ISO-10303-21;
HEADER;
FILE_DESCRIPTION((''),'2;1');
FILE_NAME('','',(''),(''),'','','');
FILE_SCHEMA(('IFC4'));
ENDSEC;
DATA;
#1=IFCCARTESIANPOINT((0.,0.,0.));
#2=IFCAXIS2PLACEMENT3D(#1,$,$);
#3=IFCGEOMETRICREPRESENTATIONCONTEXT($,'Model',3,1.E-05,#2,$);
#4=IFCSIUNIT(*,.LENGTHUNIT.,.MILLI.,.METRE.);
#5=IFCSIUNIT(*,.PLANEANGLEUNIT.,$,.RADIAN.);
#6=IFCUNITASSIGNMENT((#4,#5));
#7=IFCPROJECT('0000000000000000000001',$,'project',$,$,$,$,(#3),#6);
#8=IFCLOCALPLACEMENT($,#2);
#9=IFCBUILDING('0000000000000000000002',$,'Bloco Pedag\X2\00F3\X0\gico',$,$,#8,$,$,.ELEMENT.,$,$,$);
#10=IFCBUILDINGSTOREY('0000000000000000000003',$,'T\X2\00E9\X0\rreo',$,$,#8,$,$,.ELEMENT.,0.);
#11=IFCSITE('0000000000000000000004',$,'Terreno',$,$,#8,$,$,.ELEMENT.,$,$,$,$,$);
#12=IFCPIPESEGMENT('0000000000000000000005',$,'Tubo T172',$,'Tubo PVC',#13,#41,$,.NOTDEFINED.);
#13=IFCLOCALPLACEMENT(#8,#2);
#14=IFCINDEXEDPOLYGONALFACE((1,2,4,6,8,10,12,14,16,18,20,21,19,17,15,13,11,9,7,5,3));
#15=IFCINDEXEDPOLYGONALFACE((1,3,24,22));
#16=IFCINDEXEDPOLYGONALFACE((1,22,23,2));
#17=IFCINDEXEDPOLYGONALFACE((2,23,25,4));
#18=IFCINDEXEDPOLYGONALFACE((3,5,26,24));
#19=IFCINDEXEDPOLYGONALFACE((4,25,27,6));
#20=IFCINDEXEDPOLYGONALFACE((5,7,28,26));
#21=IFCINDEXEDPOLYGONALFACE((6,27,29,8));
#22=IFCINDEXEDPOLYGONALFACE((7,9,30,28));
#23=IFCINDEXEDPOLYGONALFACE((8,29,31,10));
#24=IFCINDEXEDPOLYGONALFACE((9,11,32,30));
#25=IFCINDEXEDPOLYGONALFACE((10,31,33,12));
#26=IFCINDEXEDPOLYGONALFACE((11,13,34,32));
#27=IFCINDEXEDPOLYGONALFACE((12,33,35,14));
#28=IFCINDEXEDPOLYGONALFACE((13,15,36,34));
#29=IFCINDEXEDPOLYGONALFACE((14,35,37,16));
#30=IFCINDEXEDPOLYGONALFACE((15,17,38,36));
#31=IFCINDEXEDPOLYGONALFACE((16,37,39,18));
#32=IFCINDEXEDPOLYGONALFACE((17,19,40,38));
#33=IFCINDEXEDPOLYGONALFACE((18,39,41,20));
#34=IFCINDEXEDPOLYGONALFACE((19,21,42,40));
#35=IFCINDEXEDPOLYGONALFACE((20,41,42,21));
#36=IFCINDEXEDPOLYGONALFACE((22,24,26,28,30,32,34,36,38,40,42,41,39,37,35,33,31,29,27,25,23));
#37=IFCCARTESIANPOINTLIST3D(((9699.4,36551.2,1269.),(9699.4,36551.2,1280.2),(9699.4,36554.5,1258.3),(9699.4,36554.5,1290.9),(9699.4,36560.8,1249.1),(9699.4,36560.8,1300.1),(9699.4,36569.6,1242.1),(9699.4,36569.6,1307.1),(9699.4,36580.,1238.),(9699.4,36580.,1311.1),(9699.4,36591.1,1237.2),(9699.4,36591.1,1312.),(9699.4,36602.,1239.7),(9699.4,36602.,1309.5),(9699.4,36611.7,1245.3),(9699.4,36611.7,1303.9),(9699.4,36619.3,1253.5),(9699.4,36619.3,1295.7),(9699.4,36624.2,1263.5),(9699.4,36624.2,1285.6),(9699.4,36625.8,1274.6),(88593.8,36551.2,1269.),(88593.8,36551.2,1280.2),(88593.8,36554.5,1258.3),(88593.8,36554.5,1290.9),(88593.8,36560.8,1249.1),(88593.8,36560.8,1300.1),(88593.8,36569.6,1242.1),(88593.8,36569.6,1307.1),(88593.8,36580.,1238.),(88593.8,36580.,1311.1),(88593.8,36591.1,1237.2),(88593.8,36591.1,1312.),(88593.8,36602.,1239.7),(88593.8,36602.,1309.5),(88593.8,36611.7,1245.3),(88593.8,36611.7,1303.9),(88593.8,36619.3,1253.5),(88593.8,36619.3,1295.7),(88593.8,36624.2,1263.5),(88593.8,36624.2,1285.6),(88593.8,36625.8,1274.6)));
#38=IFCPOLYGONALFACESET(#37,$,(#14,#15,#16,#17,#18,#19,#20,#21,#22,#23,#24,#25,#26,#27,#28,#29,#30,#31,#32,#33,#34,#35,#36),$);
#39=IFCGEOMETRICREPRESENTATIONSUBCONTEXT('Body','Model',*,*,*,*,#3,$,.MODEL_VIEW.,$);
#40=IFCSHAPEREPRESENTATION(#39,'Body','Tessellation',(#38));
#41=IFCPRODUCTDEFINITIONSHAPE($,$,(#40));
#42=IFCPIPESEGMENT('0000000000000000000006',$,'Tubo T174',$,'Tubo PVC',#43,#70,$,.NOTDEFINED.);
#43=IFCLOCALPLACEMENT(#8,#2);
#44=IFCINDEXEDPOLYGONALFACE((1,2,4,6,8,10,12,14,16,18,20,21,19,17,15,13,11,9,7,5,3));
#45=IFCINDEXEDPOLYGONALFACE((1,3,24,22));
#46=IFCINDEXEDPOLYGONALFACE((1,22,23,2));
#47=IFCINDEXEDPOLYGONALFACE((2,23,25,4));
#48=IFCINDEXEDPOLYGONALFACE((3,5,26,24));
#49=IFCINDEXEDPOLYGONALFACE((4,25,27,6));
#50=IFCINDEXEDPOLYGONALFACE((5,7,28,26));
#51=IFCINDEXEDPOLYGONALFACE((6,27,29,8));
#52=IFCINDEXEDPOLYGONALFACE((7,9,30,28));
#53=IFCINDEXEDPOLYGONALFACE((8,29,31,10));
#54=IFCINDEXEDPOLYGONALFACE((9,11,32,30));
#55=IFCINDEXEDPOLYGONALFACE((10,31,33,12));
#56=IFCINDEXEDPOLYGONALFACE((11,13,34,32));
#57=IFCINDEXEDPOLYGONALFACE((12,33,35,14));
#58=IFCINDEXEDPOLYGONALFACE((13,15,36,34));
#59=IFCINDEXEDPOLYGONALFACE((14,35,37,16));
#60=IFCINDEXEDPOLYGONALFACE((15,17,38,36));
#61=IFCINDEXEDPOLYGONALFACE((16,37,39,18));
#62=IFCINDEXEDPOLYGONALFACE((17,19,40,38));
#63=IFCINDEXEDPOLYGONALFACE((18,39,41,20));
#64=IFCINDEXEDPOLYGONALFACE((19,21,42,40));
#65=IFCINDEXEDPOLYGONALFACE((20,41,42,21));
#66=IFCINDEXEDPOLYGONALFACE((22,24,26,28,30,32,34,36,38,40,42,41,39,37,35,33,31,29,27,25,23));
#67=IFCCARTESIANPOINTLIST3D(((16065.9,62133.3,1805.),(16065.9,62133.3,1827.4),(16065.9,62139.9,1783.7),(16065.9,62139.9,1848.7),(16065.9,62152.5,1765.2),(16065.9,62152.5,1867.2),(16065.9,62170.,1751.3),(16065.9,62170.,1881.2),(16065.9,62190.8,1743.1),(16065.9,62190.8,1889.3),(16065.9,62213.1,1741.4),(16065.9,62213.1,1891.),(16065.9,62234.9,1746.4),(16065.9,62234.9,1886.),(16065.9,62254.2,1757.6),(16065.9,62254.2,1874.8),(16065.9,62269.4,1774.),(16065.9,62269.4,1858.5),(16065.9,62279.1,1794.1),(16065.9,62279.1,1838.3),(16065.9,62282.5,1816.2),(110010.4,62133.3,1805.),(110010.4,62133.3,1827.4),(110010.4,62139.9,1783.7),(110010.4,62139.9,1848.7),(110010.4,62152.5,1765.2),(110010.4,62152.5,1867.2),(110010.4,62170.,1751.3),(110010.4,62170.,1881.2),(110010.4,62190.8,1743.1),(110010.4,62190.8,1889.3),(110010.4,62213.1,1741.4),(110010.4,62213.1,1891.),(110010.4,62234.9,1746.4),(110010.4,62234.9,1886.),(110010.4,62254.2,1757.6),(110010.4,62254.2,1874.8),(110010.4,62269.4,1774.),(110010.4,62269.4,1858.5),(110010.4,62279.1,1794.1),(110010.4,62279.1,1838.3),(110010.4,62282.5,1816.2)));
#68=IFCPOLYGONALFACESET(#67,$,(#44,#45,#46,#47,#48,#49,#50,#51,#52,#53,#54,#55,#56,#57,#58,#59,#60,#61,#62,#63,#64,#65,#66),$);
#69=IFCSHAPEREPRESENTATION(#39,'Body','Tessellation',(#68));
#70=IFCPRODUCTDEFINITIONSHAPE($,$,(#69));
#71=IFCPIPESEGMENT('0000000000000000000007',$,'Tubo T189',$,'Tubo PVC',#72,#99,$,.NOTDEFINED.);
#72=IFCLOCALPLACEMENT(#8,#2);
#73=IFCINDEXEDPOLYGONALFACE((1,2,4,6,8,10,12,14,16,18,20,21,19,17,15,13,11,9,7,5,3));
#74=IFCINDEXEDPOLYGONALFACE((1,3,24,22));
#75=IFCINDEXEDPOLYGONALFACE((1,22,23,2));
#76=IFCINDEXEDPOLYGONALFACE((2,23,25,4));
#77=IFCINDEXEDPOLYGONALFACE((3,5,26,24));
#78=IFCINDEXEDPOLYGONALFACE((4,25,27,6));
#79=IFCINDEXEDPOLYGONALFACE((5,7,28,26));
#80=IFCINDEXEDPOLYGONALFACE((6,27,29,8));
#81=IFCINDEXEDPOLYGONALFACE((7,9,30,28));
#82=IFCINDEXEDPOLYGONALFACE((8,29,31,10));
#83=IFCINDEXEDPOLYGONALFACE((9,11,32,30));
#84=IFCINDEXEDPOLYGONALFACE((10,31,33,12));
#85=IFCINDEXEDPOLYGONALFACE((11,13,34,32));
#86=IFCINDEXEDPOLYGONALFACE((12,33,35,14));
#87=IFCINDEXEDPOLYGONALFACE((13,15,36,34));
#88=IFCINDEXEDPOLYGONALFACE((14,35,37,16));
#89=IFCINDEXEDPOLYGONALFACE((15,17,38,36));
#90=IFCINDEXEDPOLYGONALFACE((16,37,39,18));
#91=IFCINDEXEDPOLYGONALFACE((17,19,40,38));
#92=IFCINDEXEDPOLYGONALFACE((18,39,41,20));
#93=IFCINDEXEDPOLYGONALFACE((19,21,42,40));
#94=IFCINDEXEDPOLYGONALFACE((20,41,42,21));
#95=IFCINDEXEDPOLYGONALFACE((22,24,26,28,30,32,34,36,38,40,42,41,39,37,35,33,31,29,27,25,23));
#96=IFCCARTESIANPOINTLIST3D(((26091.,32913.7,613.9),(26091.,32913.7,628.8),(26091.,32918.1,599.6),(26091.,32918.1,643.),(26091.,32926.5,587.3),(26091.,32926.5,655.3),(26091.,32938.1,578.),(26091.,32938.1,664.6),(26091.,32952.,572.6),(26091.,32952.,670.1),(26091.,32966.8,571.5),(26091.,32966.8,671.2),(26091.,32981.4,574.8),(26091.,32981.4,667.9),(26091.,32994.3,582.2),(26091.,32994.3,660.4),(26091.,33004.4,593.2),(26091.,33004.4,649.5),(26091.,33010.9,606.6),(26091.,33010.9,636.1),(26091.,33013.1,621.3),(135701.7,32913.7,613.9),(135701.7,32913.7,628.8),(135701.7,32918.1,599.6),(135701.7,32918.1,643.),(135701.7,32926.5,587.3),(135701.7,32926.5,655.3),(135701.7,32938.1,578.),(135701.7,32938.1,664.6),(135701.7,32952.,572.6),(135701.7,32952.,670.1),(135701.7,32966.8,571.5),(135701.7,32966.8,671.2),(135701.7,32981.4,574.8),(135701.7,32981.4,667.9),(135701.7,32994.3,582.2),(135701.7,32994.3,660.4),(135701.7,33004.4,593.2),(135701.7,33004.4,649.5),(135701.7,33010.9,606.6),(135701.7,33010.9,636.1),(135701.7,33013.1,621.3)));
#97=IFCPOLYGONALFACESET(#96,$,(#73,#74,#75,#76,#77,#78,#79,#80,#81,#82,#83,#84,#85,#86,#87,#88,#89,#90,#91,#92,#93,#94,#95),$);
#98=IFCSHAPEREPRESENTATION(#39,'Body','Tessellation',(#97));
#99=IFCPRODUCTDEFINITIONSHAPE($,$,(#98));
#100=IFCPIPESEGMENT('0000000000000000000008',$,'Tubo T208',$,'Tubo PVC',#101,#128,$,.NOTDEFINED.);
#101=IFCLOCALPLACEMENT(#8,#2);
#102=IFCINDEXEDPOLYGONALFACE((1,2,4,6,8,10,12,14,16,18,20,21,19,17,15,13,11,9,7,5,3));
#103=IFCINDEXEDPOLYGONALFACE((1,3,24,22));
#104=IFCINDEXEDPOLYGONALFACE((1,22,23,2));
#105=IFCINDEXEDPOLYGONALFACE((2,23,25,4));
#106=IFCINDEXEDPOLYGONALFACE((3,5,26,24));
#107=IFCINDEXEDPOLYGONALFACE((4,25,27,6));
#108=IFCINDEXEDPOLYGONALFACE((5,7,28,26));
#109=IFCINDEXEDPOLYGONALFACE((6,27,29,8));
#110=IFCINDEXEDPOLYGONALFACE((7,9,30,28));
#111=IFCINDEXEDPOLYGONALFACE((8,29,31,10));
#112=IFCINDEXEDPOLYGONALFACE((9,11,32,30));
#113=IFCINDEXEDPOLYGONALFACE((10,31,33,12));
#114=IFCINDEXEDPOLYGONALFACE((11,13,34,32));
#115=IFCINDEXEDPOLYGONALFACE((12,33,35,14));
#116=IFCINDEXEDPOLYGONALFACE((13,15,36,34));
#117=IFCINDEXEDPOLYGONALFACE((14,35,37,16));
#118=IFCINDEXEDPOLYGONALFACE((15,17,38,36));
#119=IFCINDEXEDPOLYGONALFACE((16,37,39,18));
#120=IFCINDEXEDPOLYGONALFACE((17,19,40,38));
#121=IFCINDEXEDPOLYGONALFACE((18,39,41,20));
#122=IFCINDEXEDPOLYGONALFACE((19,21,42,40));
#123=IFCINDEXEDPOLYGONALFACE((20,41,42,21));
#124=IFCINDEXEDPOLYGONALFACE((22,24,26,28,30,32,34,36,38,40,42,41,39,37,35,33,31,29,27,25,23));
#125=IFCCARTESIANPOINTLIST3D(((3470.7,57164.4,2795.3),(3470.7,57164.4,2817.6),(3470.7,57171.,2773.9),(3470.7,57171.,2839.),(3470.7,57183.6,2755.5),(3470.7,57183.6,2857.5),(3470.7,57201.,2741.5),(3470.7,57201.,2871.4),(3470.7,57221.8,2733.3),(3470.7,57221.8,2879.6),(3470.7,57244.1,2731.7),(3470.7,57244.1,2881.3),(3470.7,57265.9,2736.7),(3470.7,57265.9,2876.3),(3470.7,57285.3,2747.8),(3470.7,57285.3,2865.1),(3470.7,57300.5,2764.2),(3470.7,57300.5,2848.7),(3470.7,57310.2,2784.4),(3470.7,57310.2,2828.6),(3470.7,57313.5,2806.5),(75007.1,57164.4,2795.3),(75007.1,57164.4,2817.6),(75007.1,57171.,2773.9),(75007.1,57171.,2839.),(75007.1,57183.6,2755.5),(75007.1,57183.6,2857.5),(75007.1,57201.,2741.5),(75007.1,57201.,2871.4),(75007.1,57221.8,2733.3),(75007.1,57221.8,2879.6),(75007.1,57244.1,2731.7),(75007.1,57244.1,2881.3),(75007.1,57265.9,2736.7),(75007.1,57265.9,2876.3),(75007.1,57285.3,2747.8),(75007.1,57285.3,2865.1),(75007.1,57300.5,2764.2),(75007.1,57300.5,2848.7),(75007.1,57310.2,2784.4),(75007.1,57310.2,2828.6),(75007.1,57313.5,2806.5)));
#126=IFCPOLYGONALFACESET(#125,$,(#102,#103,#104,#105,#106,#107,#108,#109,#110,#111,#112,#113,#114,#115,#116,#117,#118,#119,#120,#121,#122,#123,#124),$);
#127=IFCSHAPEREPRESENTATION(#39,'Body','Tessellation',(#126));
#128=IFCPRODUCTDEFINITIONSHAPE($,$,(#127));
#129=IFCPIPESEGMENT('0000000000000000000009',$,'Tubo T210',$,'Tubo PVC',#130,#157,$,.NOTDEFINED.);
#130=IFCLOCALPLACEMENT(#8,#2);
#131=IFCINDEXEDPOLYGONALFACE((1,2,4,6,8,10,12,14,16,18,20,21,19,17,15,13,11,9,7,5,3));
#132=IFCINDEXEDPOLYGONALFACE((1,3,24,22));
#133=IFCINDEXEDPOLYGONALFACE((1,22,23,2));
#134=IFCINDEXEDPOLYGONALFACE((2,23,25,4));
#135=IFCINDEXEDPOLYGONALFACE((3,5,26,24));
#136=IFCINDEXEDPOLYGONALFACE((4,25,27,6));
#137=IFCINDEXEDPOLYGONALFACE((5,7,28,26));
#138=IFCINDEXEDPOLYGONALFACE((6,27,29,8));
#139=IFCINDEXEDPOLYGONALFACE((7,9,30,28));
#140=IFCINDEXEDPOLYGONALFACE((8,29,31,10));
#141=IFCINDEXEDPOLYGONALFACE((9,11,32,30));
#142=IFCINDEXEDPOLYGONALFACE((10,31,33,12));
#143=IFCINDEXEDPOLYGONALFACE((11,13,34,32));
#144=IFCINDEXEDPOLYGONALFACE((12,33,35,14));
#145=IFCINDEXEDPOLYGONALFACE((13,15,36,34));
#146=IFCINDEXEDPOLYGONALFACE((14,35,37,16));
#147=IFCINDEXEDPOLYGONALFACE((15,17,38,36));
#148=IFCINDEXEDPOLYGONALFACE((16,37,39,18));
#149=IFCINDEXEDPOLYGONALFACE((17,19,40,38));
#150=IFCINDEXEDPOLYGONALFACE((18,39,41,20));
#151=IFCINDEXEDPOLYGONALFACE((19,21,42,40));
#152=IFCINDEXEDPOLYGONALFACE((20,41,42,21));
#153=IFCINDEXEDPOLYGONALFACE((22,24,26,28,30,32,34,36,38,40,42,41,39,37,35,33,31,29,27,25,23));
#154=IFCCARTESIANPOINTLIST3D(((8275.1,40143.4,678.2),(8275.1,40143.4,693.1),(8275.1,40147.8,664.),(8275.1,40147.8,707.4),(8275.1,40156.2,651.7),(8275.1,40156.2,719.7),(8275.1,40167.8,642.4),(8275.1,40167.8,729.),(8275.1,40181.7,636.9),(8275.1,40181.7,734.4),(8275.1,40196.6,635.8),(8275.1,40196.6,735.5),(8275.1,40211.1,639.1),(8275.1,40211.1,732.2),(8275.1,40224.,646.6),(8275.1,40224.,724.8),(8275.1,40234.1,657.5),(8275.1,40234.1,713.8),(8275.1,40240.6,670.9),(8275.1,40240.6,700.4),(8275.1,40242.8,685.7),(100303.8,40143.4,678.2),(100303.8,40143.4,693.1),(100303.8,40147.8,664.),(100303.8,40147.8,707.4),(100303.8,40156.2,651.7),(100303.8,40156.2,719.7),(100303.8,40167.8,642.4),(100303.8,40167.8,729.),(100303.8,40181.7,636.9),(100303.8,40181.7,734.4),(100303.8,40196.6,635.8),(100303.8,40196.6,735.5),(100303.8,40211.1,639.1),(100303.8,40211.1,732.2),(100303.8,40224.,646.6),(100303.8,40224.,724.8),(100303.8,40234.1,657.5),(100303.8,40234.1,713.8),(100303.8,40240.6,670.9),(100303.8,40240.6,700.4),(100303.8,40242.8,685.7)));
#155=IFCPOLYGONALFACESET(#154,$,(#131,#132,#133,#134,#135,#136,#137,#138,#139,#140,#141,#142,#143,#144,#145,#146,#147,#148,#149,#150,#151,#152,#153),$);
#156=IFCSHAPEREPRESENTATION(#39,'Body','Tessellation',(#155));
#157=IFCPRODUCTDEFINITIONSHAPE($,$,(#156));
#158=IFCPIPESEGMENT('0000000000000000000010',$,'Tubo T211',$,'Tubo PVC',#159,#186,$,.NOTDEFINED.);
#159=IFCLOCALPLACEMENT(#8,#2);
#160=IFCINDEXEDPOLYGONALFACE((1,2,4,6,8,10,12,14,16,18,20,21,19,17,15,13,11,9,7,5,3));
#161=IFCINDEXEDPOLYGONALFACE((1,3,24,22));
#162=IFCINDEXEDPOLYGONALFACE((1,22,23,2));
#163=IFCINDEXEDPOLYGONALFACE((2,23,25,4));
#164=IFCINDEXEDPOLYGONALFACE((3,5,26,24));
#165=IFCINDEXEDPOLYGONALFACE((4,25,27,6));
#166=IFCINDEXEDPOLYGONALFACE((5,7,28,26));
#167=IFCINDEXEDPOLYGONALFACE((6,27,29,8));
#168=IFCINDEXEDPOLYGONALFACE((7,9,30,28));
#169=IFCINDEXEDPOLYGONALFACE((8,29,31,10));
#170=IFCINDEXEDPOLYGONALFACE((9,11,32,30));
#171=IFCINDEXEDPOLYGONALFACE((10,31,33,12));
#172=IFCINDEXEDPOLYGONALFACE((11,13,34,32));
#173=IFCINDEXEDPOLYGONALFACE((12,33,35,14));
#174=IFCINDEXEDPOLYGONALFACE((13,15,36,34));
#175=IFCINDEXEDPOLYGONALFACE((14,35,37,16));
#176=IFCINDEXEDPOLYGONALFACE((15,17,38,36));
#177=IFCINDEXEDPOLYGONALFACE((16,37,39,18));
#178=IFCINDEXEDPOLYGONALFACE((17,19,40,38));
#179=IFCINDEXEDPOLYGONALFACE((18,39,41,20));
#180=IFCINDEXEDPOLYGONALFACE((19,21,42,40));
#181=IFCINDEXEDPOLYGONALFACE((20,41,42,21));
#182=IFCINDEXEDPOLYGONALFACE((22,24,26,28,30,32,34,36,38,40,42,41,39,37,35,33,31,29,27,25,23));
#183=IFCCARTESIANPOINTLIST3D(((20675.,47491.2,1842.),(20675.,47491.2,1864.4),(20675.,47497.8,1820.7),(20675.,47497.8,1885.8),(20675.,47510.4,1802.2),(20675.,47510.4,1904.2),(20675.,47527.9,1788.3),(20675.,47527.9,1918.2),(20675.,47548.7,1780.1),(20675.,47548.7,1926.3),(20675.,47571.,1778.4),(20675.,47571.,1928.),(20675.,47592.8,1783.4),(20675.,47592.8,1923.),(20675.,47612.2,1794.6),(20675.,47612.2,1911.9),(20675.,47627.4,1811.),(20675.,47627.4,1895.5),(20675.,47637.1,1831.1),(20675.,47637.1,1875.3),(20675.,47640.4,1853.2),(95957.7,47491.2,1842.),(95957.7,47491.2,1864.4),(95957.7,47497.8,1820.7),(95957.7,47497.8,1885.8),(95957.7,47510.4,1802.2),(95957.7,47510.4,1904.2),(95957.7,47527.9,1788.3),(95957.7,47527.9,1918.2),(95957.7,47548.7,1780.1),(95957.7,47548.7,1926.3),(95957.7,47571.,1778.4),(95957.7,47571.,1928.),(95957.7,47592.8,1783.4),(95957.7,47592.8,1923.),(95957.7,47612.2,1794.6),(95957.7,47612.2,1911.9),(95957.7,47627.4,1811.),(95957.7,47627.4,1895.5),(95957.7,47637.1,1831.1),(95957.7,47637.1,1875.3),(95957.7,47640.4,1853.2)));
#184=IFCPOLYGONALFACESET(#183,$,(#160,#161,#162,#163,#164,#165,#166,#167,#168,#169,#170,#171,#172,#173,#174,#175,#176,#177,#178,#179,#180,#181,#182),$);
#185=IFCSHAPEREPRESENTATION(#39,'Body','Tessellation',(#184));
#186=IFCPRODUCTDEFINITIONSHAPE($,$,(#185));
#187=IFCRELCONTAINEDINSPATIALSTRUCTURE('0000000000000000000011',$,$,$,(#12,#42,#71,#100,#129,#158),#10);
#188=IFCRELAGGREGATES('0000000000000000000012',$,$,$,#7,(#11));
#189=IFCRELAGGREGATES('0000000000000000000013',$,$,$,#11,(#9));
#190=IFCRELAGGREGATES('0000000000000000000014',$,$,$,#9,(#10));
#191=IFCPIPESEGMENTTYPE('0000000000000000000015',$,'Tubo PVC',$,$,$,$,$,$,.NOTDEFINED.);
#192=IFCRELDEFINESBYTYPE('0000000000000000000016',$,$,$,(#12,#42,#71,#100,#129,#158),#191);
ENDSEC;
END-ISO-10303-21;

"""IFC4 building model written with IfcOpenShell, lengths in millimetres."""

from ifc_helpers import new_model, si_unit, frame, origin, origin_2d, place, context, subcontext, project, spatial, circle, extrude, type_object, element, save


model = new_model("IFC4")

# Units and contexts
model_context = context("Model", 3, precision=1e-05, world=origin())
body_context = subcontext(model_context, "Body", "Model", "MODEL_VIEW")
ifc_project = project(units=[si_unit("LENGTHUNIT", "METRE", prefix="MILLI"), si_unit("PLANEANGLEUNIT", "RADIAN")], contexts=[model_context])

# Site, building, storey
placement = place(None, origin())
site = spatial("IfcSite", under=ifc_project, at=placement, Name="Terreno", CompositionType="ELEMENT")
building = spatial("IfcBuilding", under=site, at=placement, Name="Bloco Pedagógico", CompositionType="ELEMENT")
storey = spatial("IfcBuildingStorey", under=building, at=placement, Name="Térreo", CompositionType="ELEMENT", Elevation=0.0)

# Pipe segments
pipe_segment_type = type_object("IfcPipeSegmentType", Name="Tubo PVC", PredefinedType="NOTDEFINED")
pipe_segment_1_placement = place(None, frame((9699.4, 36588.3, 1274.6), z_axis=(1.0, 0.0, 0.0), x_axis=(0.0, 1.0, 0.0)))
element("IfcPipeSegment", 1, at=pipe_segment_1_placement, inside=storey, type_object=pipe_segment_type, Name="Tubo T172", ObjectType="Tubo PVC", PredefinedType="NOTDEFINED", context=body_context, shape_type="SweptSolid", body=[
    extrude(circle(Radius=37.5, at=origin_2d()), None, (0.0, 0.0, 1.0), 78894.5),
])
pipe_segment_2_placement = place(None, frame((16065.9, 62207.5, 1816.2), z_axis=(1.0, 0.0, 0.0), x_axis=(0.0, 1.0, 0.0)))
element("IfcPipeSegment", 2, at=pipe_segment_2_placement, inside=storey, type_object=pipe_segment_type, Name="Tubo T174", ObjectType="Tubo PVC", PredefinedType="NOTDEFINED", context=body_context, shape_type="SweptSolid", body=[
    extrude(circle(Radius=75.0, at=origin_2d()), None, (0.0, 0.0, 1.0), 93944.6),
])
pipe_segment_3_placement = place(None, frame((26091.0, 32963.1, 621.3), z_axis=(1.0, 0.0, 0.0), x_axis=(0.0, 1.0, 0.0)))
element("IfcPipeSegment", 3, at=pipe_segment_3_placement, inside=storey, type_object=pipe_segment_type, Name="Tubo T189", ObjectType="Tubo PVC", PredefinedType="NOTDEFINED", context=body_context, shape_type="SweptSolid", body=[
    extrude(circle(Radius=50.0, at=origin_2d()), None, (0.0, 0.0, 1.0), 109610.6),
])
pipe_segment_4_placement = place(None, frame((3470.7, 57238.5, 2806.5), z_axis=(1.0, 0.0, 0.0), x_axis=(0.0, 1.0, 0.0)))
element("IfcPipeSegment", 4, at=pipe_segment_4_placement, inside=storey, type_object=pipe_segment_type, Name="Tubo T208", ObjectType="Tubo PVC", PredefinedType="NOTDEFINED", context=body_context, shape_type="SweptSolid", body=[
    extrude(circle(Radius=75.0, at=origin_2d()), None, (0.0, 0.0, 1.0), 71536.4),
])
pipe_segment_5_placement = place(None, frame((8275.1, 40192.8, 685.7), z_axis=(1.0, 0.0, 0.0), x_axis=(0.0, 1.0, 0.0)))
element("IfcPipeSegment", 5, at=pipe_segment_5_placement, inside=storey, type_object=pipe_segment_type, Name="Tubo T210", ObjectType="Tubo PVC", PredefinedType="NOTDEFINED", context=body_context, shape_type="SweptSolid", body=[
    extrude(circle(Radius=50.0, at=origin_2d()), None, (0.0, 0.0, 1.0), 92028.8),
])
pipe_segment_6_placement = place(None, frame((20675.0, 47565.4, 1853.2), z_axis=(1.0, 0.0, 0.0), x_axis=(0.0, 1.0, 0.0)))
element("IfcPipeSegment", 6, at=pipe_segment_6_placement, inside=storey, type_object=pipe_segment_type, Name="Tubo T211", ObjectType="Tubo PVC", PredefinedType="NOTDEFINED", context=body_context, shape_type="SweptSolid", body=[
    extrude(circle(Radius=75.0, at=origin_2d()), None, (0.0, 0.0, 1.0), 75282.7),
])

save(model, "model.ifc")
